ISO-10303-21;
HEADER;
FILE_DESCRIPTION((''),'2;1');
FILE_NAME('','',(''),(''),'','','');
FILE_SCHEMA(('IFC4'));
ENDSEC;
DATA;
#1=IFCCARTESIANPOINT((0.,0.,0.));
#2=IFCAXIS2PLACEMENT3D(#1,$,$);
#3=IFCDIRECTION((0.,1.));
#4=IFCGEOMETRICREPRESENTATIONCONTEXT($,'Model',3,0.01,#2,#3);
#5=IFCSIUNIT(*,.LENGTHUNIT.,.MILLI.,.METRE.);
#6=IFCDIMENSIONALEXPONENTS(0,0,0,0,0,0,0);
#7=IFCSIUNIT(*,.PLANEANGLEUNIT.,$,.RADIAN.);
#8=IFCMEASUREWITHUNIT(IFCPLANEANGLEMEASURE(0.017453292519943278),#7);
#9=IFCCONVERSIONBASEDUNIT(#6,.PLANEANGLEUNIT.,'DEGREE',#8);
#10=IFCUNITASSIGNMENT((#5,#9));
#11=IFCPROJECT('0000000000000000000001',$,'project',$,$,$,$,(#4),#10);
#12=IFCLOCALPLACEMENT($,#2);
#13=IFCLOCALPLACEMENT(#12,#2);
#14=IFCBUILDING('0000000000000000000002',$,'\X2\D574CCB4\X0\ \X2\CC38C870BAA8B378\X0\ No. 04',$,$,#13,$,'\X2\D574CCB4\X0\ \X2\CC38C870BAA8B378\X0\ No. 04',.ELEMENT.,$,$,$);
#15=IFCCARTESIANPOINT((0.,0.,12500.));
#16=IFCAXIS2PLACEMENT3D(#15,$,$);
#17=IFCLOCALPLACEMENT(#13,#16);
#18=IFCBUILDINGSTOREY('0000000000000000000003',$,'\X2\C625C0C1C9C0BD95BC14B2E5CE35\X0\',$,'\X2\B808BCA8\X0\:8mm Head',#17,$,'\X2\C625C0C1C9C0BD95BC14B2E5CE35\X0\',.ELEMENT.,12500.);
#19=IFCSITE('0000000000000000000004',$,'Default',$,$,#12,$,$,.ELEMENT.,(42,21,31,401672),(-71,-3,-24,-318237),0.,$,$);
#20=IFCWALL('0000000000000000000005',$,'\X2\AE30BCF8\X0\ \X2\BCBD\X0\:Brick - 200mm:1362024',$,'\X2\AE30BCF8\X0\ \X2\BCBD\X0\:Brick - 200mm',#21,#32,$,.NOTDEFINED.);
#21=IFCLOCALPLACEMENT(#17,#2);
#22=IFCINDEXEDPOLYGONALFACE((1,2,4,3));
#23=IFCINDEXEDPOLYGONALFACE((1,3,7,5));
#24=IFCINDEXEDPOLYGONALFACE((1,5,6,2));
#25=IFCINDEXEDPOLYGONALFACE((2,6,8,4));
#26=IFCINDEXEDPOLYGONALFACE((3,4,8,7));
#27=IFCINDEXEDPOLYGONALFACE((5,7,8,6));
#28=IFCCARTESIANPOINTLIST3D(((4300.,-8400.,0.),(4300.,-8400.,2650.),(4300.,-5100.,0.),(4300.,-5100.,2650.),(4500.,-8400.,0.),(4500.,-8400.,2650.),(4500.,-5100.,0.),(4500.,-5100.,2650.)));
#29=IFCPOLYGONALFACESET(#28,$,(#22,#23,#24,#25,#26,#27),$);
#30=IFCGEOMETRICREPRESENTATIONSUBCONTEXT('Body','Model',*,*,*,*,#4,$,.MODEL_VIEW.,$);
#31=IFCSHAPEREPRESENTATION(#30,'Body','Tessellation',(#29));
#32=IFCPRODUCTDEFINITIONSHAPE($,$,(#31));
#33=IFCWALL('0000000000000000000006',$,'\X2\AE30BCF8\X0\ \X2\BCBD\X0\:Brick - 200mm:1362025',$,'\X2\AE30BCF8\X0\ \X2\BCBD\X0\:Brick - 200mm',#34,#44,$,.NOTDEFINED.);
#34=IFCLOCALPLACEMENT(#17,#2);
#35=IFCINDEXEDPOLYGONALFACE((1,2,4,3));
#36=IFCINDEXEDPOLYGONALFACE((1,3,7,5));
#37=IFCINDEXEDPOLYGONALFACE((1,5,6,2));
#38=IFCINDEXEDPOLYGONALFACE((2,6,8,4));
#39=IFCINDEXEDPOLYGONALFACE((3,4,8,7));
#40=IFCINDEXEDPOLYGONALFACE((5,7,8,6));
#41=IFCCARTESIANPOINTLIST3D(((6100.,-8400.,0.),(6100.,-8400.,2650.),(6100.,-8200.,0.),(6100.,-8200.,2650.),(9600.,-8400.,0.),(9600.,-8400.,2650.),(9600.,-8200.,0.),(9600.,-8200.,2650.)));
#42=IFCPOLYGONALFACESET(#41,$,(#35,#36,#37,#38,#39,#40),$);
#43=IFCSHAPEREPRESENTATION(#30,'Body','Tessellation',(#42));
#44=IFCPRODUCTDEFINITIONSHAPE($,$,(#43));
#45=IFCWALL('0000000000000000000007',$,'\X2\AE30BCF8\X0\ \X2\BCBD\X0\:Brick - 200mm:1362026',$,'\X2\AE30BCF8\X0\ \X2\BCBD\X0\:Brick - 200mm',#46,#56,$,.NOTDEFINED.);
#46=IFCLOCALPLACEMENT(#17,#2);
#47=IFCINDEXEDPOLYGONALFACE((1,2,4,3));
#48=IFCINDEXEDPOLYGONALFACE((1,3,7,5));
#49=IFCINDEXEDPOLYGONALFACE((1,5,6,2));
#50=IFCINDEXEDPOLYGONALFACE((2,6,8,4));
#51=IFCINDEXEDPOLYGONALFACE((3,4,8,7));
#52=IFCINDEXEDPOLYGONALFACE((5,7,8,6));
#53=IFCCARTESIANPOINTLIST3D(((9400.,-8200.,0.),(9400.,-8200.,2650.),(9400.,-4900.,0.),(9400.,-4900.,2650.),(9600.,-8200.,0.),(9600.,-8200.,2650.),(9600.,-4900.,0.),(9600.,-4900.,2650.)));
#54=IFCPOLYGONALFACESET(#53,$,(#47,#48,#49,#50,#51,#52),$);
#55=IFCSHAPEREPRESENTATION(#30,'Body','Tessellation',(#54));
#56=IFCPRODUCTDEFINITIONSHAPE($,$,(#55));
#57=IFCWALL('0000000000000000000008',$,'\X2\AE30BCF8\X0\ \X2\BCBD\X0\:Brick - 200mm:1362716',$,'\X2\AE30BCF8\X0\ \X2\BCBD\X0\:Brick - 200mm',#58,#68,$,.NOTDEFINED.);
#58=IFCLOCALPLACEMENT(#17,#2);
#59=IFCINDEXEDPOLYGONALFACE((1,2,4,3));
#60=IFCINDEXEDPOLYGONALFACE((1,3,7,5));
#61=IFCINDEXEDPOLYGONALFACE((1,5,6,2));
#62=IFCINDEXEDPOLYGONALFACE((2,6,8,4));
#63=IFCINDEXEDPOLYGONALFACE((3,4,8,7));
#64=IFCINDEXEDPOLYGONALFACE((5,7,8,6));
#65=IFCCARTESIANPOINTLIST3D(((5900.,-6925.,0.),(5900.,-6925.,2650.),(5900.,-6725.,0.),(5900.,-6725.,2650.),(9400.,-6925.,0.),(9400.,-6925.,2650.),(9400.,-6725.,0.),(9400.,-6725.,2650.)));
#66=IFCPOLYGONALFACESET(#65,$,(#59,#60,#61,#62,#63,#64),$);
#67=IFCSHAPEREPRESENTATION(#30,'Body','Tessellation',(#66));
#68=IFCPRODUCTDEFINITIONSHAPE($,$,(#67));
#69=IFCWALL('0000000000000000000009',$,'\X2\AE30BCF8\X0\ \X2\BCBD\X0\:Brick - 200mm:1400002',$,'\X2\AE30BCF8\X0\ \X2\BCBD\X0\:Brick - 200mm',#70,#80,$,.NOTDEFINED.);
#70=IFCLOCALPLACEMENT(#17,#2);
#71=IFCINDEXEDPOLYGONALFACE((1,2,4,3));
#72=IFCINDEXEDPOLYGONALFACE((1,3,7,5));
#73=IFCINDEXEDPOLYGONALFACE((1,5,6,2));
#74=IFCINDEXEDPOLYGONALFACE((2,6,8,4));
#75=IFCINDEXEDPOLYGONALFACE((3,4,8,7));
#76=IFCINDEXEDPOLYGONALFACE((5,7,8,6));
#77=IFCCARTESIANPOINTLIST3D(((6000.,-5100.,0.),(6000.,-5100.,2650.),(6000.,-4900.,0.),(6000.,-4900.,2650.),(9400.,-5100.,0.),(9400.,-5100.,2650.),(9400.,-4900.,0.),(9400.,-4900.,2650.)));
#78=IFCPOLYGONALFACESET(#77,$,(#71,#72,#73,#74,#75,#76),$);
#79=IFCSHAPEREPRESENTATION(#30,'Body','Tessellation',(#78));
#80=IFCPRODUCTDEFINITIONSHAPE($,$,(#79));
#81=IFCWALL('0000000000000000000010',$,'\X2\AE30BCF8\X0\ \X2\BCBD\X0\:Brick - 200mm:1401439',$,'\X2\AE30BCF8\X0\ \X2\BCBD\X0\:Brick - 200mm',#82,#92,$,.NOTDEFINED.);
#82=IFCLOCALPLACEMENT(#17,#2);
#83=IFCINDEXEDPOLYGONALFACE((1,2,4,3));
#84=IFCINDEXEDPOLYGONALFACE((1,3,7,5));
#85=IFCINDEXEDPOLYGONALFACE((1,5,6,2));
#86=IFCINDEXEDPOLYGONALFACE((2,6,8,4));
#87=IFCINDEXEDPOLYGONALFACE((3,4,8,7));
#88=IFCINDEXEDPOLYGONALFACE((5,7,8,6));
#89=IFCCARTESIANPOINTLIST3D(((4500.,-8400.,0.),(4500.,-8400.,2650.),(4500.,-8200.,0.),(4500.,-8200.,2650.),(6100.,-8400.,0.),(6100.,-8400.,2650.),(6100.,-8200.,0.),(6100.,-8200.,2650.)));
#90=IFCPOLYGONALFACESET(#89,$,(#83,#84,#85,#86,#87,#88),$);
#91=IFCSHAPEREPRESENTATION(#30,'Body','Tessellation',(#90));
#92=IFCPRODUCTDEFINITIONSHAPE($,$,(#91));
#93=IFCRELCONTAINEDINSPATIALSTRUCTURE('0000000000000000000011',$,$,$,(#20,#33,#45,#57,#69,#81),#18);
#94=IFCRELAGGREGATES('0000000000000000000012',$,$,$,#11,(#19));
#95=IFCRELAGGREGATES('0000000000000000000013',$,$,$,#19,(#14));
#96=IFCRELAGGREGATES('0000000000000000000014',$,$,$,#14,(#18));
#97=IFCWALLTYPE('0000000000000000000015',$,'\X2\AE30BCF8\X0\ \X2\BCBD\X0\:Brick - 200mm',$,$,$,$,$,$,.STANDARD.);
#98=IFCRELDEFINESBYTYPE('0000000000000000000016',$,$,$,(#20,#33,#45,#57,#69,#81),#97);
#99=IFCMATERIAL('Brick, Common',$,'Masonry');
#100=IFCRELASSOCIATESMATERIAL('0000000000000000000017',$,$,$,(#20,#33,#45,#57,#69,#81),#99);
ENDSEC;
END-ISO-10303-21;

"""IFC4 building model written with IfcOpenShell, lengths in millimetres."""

from ifc_helpers import new_model, entity, si_unit, converted_unit, direction, frame, origin, place, context, subcontext, project, spatial, indexed_curve, outline, extrude, material, type_object, element, save


model = new_model("IFC4")

# Units and contexts
model_context = context("Model", 3, precision=0.01, world=origin(), true_north=direction((0.0, 1.0)))
body_context = subcontext(model_context, "Body", "Model", "MODEL_VIEW")
ifc_project = project(units=[si_unit("LENGTHUNIT", "METRE", prefix="MILLI"), converted_unit("PLANEANGLEUNIT", "DEGREE", entity("IfcPlaneAngleMeasure", 0.017453292519943278), si_unit("PLANEANGLEUNIT", "RADIAN"), dimensions=[0, 0, 0, 0, 0, 0, 0])], contexts=[model_context])

# Site, building, storey
site_placement = place(None, origin())
site = spatial("IfcSite", under=ifc_project, at=site_placement, Name="Default", CompositionType="ELEMENT", RefLatitude=(42, 21, 31, 401672), RefLongitude=(-71, -3, -24, -318237), RefElevation=0.0)
building_placement = place(site_placement, origin())
building = spatial("IfcBuilding", under=site, at=building_placement, Name="해체 참조모델 No. 04", LongName="해체 참조모델 No. 04", CompositionType="ELEMENT")
storey_placement = place(building_placement, frame((0.0, 0.0, 12500.0)))
storey = spatial("IfcBuildingStorey", under=building, at=storey_placement, Name="옥상지붕바닥층", ObjectType="레벨:8mm Head", LongName="옥상지붕바닥층", CompositionType="ELEMENT", Elevation=12500.0)

# Walls
ifc_material_1 = material(Name="Brick, Common", Category="Masonry")
wall_type = type_object("IfcWallType", Name="기본 벽:Brick - 200mm", PredefinedType="STANDARD")
wall_1_placement = place(storey_placement, frame((4400.0, -8400.0, 0.0), z_axis=(0.0, 0.0, 1.0), x_axis=(0.0, 1.0, 0.0)))
element("IfcWall", 1, at=wall_1_placement, inside=storey, type_object=wall_type, material=ifc_material_1, Name="기본 벽:Brick - 200mm:1362024", ObjectType="기본 벽:Brick - 200mm", PredefinedType="NOTDEFINED", context=body_context, shape_type="SweptSolid", body=[
    extrude(outline(indexed_curve([(3300.0, 100.0), (0.0, 100.0), (0.0, -100.0), (3300.0, -100.0), (3300.0, 100.0)], self_intersect=False)), origin(), (0.0, 0.0, 1.0), 2650.0),
])
wall_2_placement = place(storey_placement, frame((9600.0, -8300.0, 0.0), z_axis=(0.0, 0.0, 1.0), x_axis=(-1.0, 0.0, 0.0)))
element("IfcWall", 2, at=wall_2_placement, inside=storey, type_object=wall_type, material=ifc_material_1, Name="기본 벽:Brick - 200mm:1362025", ObjectType="기본 벽:Brick - 200mm", PredefinedType="NOTDEFINED", context=body_context, shape_type="SweptSolid", body=[
    extrude(outline(indexed_curve([(3500.0, 100.0), (0.0, 100.0), (0.0, -100.0), (3500.0, -100.0), (3500.0, 100.0)], self_intersect=False)), origin(), (0.0, 0.0, 1.0), 2650.0),
])
wall_3_placement = place(storey_placement, frame((9500.0, -4900.0, 0.0), z_axis=(0.0, 0.0, 1.0), x_axis=(0.0, -1.0, 0.0)))
element("IfcWall", 3, at=wall_3_placement, inside=storey, type_object=wall_type, material=ifc_material_1, Name="기본 벽:Brick - 200mm:1362026", ObjectType="기본 벽:Brick - 200mm", PredefinedType="NOTDEFINED", context=body_context, shape_type="SweptSolid", body=[
    extrude(outline(indexed_curve([(3300.0, 100.0), (0.0, 100.0), (0.0, -100.0), (3300.0, -100.0), (3300.0, 100.0)], self_intersect=False)), origin(), (0.0, 0.0, 1.0), 2650.0),
])
wall_4_placement = place(storey_placement, frame((5900.0, -6825.0, 0.0)))
element("IfcWall", 4, at=wall_4_placement, inside=storey, type_object=wall_type, material=ifc_material_1, Name="기본 벽:Brick - 200mm:1362716", ObjectType="기본 벽:Brick - 200mm", PredefinedType="NOTDEFINED", context=body_context, shape_type="SweptSolid", body=[
    extrude(outline(indexed_curve([(3500.0, 100.0), (0.0, 100.0), (0.0, -100.0), (3500.0, -100.0), (3500.0, 100.0)], self_intersect=False)), origin(), (0.0, 0.0, 1.0), 2650.0),
])
wall_5_placement = place(storey_placement, frame((6000.0, -5000.0, 0.0)))
element("IfcWall", 5, at=wall_5_placement, inside=storey, type_object=wall_type, material=ifc_material_1, Name="기본 벽:Brick - 200mm:1400002", ObjectType="기본 벽:Brick - 200mm", PredefinedType="NOTDEFINED", context=body_context, shape_type="SweptSolid", body=[
    extrude(outline(indexed_curve([(3400.0, 100.0), (0.0, 100.0), (0.0, -100.0), (3400.0, -100.0), (3400.0, 100.0)], self_intersect=False)), origin(), (0.0, 0.0, 1.0), 2650.0),
])
wall_6_placement = place(storey_placement, frame((6100.0, -8300.0, 0.0), z_axis=(0.0, 0.0, 1.0), x_axis=(-1.0, 0.0, 0.0)))
element("IfcWall", 6, at=wall_6_placement, inside=storey, type_object=wall_type, material=ifc_material_1, Name="기본 벽:Brick - 200mm:1401439", ObjectType="기본 벽:Brick - 200mm", PredefinedType="NOTDEFINED", context=body_context, shape_type="SweptSolid", body=[
    extrude(outline(indexed_curve([(1600.0, 100.0), (0.0, 100.0), (0.0, -100.0), (1600.0, -100.0), (1600.0, 100.0)], self_intersect=False)), origin(), (0.0, 0.0, 1.0), 2650.0),
])

save(model, "model.ifc")
